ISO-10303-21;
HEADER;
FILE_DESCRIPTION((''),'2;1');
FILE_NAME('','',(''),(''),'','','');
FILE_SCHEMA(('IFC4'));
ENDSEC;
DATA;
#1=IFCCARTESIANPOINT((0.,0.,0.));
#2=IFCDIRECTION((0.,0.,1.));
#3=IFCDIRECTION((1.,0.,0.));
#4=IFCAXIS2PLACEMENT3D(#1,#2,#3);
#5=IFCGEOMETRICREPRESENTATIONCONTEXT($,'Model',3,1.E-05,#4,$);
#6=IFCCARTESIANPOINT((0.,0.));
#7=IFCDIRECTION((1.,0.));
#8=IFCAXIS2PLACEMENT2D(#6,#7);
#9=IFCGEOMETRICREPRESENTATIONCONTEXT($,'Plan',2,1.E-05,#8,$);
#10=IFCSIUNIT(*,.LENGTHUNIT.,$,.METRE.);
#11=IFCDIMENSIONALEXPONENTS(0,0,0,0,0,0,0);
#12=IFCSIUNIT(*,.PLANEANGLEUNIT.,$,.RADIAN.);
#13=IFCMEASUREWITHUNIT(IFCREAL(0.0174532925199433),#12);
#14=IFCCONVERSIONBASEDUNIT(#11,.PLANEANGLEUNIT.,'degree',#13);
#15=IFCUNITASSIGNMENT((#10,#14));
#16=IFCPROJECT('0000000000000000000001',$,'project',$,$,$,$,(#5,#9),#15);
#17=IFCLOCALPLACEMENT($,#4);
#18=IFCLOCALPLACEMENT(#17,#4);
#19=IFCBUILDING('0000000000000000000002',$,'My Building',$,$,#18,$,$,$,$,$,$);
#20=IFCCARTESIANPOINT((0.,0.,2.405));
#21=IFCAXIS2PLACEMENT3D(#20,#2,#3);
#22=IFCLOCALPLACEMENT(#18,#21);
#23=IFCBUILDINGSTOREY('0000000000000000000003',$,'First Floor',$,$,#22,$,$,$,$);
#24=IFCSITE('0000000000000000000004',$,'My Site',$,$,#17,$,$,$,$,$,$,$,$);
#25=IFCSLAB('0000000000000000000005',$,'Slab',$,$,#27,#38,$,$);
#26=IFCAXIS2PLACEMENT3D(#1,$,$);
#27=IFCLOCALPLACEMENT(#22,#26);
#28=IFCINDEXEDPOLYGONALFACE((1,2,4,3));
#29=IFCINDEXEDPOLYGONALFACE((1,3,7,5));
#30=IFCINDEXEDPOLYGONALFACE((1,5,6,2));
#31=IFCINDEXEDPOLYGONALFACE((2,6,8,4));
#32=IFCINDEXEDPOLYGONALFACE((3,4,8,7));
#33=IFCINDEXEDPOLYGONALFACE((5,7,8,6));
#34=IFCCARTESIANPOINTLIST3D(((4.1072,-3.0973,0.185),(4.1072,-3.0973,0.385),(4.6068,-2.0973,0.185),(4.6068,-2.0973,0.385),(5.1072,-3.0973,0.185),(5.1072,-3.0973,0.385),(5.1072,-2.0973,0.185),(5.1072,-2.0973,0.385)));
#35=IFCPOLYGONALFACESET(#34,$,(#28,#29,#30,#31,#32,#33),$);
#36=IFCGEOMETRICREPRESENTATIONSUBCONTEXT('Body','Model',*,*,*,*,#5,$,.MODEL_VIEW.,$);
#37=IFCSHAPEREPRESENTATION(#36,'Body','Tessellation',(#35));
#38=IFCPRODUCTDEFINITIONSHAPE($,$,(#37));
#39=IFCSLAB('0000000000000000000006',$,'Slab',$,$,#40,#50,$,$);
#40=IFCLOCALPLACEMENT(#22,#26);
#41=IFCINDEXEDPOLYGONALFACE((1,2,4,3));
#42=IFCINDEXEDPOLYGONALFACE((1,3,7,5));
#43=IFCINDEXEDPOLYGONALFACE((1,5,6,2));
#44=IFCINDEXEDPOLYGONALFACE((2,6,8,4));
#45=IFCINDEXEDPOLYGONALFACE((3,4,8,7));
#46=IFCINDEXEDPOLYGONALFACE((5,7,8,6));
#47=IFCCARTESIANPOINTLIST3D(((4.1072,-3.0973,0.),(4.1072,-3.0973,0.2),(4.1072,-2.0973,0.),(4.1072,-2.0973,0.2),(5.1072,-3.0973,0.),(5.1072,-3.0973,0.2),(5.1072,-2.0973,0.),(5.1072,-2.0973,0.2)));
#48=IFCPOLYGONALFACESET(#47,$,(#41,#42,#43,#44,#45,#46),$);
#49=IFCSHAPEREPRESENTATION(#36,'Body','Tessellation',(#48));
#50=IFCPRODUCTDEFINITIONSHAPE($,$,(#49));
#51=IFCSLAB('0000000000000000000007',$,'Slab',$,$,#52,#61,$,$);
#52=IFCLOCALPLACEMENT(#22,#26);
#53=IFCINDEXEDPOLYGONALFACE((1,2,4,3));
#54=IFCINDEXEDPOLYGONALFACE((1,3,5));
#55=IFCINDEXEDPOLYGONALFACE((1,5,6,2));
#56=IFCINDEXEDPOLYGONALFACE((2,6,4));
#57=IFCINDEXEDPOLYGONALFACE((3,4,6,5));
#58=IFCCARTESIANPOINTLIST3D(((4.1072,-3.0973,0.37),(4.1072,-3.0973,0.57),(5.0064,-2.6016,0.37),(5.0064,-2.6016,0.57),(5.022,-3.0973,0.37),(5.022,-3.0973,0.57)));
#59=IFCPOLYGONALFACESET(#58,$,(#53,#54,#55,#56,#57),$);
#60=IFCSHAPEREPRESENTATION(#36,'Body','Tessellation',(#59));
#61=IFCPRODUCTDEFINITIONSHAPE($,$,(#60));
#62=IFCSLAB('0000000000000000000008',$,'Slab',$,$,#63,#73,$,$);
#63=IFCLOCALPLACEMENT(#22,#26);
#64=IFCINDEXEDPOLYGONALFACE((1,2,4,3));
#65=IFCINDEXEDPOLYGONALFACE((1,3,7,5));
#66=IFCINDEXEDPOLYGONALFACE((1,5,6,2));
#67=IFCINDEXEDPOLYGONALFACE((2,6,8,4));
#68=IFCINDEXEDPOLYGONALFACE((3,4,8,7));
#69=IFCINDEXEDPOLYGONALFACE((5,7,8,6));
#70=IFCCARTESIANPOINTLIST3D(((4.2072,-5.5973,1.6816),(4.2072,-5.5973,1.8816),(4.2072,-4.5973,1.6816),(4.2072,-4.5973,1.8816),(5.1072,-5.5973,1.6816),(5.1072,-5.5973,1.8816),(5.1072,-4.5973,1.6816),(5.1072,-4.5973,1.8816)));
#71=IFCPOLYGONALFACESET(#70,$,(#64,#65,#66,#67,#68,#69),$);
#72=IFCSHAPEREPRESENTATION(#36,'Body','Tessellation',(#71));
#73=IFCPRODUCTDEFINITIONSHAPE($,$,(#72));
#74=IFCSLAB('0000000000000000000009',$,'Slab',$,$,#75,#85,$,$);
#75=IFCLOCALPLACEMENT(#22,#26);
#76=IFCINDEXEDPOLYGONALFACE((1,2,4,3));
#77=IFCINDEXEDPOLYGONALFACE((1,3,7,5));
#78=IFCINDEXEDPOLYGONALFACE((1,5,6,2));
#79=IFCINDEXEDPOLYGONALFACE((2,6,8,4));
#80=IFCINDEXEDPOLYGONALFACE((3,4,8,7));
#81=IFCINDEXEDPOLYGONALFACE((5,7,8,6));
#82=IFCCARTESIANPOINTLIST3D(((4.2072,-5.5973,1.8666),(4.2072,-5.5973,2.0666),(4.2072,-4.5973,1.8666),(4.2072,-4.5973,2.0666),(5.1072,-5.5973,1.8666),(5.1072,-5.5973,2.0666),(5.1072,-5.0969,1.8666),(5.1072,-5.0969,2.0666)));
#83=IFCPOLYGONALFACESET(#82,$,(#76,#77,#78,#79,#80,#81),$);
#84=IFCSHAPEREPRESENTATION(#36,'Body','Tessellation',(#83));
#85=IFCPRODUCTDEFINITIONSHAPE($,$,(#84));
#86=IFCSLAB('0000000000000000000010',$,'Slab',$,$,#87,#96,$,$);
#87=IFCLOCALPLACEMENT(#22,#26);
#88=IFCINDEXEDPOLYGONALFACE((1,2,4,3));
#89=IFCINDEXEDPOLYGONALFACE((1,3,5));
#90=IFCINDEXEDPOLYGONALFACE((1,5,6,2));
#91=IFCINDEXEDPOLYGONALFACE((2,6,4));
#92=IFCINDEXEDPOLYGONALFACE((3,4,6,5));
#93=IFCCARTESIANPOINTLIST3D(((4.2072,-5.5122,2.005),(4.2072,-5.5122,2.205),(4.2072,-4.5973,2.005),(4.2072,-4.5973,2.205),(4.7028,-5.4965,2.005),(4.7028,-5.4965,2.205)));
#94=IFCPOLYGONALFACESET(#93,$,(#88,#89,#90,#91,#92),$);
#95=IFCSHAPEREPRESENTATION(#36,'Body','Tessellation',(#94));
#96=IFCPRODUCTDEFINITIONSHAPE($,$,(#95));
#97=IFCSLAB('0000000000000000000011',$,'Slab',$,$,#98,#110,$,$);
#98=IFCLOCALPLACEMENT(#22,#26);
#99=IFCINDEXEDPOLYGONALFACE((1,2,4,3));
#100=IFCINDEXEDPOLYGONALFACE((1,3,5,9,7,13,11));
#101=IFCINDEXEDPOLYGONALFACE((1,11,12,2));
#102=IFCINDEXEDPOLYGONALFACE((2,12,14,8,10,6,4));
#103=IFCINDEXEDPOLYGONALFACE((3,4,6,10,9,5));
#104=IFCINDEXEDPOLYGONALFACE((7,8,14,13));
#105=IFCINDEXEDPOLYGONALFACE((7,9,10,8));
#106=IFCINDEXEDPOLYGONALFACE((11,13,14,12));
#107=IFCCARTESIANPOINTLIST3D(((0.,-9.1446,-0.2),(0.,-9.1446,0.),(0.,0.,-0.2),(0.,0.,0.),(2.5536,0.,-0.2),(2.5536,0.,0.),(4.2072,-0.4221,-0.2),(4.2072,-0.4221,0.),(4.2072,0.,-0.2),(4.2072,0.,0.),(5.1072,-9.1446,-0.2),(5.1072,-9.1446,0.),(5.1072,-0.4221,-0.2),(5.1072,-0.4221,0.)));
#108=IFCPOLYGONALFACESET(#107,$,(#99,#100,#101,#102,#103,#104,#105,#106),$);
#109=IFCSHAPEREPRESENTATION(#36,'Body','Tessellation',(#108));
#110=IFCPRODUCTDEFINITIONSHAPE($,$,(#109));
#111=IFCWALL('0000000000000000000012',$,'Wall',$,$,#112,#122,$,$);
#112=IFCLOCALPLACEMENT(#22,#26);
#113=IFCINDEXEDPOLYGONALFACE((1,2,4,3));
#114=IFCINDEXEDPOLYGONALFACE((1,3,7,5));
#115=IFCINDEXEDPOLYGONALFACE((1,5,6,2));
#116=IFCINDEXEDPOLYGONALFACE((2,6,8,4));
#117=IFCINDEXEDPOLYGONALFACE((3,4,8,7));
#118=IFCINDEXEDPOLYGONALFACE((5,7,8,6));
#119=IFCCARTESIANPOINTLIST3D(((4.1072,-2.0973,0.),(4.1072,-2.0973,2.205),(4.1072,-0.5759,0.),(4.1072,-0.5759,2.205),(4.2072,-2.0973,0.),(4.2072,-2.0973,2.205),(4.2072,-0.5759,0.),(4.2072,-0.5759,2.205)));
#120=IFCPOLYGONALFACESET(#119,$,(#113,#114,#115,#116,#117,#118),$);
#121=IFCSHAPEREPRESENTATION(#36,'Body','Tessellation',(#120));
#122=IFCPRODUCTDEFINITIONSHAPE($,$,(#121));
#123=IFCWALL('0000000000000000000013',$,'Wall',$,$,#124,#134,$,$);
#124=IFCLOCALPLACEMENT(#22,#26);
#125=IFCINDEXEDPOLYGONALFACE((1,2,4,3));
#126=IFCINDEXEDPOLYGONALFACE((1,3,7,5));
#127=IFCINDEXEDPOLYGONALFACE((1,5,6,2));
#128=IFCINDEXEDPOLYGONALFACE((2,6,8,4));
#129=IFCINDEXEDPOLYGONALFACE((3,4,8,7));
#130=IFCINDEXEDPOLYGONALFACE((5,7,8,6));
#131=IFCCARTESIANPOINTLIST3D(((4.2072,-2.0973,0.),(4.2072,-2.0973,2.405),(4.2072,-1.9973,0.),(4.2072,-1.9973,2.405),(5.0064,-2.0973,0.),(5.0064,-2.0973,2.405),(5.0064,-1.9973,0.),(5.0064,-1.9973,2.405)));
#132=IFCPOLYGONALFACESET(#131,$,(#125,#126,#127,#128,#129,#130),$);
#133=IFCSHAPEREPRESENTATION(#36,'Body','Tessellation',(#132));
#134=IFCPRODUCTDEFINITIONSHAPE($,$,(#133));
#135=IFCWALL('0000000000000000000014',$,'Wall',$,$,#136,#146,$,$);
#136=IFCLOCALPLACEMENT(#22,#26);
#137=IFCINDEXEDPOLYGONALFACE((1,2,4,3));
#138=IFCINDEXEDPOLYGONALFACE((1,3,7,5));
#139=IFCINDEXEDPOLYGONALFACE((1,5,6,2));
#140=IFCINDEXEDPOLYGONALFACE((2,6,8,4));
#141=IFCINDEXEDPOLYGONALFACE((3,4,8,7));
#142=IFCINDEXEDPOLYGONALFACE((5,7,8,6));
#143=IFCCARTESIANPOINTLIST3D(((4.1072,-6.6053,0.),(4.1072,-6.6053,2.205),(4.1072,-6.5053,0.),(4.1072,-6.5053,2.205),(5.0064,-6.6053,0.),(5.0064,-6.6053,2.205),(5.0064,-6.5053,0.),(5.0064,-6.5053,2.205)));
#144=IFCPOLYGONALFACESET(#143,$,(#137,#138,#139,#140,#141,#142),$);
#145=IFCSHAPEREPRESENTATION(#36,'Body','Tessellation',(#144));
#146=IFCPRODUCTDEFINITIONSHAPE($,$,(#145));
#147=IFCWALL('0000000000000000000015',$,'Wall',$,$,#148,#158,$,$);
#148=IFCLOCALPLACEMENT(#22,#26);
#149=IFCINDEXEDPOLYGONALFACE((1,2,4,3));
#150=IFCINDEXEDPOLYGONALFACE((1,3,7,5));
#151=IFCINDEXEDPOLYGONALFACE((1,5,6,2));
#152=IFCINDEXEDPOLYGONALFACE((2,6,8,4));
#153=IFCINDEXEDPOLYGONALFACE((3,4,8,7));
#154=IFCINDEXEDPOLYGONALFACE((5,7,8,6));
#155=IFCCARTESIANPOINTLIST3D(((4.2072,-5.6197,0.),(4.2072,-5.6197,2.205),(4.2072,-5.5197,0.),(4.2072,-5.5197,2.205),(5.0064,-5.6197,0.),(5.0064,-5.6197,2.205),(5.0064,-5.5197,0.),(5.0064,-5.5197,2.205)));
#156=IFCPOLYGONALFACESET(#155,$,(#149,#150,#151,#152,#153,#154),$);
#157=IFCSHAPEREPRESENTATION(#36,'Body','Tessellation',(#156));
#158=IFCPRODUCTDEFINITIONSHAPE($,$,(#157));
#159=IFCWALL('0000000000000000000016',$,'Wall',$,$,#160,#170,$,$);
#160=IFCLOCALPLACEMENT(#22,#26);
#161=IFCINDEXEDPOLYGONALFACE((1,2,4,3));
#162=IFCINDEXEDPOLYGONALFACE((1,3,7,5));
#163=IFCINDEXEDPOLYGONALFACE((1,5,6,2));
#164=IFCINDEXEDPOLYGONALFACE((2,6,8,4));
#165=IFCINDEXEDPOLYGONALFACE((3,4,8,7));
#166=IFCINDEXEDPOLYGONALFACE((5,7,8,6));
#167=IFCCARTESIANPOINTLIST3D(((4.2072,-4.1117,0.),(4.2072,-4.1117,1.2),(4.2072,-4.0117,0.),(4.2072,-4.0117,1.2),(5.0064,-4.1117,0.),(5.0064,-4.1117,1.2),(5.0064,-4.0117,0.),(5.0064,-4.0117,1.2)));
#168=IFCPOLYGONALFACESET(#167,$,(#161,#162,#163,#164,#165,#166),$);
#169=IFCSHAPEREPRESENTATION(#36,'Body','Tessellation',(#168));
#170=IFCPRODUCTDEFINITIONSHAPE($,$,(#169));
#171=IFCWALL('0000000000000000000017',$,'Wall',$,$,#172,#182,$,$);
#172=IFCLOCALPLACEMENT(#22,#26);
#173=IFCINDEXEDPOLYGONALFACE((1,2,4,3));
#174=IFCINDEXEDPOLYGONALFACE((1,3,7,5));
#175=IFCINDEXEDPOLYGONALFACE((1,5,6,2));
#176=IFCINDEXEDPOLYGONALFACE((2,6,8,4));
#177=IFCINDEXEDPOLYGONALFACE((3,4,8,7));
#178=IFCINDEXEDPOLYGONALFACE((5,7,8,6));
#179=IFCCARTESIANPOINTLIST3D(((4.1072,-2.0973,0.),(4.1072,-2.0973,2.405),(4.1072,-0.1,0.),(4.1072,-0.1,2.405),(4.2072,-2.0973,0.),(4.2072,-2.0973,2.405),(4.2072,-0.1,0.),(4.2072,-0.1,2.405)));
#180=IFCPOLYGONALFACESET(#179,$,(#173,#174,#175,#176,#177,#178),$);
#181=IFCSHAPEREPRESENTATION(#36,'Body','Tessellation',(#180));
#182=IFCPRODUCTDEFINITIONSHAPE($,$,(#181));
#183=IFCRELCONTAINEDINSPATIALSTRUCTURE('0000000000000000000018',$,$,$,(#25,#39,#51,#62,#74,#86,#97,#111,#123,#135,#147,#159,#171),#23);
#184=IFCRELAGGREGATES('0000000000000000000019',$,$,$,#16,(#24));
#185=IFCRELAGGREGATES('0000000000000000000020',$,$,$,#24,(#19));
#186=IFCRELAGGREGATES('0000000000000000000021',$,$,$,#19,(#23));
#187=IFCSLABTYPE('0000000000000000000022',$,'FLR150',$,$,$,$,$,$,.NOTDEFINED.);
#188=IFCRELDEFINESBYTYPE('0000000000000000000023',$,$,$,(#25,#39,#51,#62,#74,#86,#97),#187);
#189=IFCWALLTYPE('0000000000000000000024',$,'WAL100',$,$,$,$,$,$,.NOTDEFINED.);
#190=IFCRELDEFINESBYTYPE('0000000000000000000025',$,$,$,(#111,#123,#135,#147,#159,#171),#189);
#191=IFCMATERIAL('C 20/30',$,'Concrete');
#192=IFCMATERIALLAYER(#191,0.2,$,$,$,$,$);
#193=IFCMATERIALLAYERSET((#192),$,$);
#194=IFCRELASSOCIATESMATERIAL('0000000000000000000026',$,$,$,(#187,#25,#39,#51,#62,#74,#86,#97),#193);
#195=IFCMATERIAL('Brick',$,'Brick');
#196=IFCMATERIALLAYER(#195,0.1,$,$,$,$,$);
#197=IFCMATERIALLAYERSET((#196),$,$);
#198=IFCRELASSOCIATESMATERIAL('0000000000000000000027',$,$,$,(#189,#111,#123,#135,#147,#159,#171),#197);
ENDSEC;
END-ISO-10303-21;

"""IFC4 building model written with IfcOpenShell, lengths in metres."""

from ifc_helpers import new_model, entity, si_unit, converted_unit, frame, origin_with_axes, origin_2d_with_axis, place, context, subcontext, project, spatial, line, indexed_curve, outline, extrude, material, layer, layer_set, layer_usage, type_object, element, save


model = new_model("IFC4")

# Units and contexts
model_context = context("Model", 3, precision=1e-05, world=origin_with_axes())
plan_context = context("Plan", 2, precision=1e-05, world=origin_2d_with_axis())
body_context = subcontext(model_context, "Body", "Model", "MODEL_VIEW")
ifc_project = project(units=[si_unit("LENGTHUNIT", "METRE"), converted_unit("PLANEANGLEUNIT", "degree", entity("IfcReal", 0.0174532925199433), si_unit("PLANEANGLEUNIT", "RADIAN"), dimensions=[0, 0, 0, 0, 0, 0, 0])], contexts=[model_context, plan_context])

# Site, building, storey
site_placement = place(None, origin_with_axes())
site = spatial("IfcSite", under=ifc_project, at=site_placement, Name="My Site")
building_placement = place(site_placement, origin_with_axes())
building = spatial("IfcBuilding", under=site, at=building_placement, Name="My Building")
storey_placement = place(building_placement, frame((0.0, 0.0, 2.405), z_axis=(0.0, 0.0, 1.0), x_axis=(1.0, 0.0, 0.0)))
storey = spatial("IfcBuildingStorey", under=building, at=storey_placement, Name="First Floor")

# Slabs
ifc_material_1 = material(Name="C 20/30", Category="Concrete")
ifc_layer_1 = layer(ifc_material_1, 0.2)
ifc_layer_set_1 = layer_set([ifc_layer_1])
ifc_layer_usage_1 = layer_usage(ifc_layer_set_1, "AXIS3", "POSITIVE", 0.0)
slab_type = type_object("IfcSlabType", Name="FLR150", PredefinedType="NOTDEFINED", material=ifc_layer_set_1)
slab_1_placement = place(storey_placement, frame((4.1072, -3.0973, 0.185), z_axis=(0.0, 0.0, 1.0), x_axis=(1.0, 0.0, 0.0)))
element("IfcSlab", 1, at=slab_1_placement, inside=storey, type_object=slab_type, material=ifc_layer_usage_1, Name="Slab", context=body_context, shape_type="SweptSolid", body=[
    extrude(outline(indexed_curve([(0.0, 0.0), (1.0, 0.0), (1.0, 1.0), (0.4996, 1.0)], segments=[line(3, 2), line(2, 1), line(1, 4), line(4, 3)], self_intersect=False)), None, (0.0, 0.0, 1.0), 0.2),
])
ifc_layer_usage_2 = layer_usage(ifc_layer_set_1, "AXIS3", "POSITIVE", 0.0)
slab_2_placement = place(storey_placement, frame((4.1072, -3.0973, 0.0), z_axis=(0.0, 0.0, 1.0), x_axis=(1.0, 0.0, 0.0)))
element("IfcSlab", 2, at=slab_2_placement, inside=storey, type_object=slab_type, material=ifc_layer_usage_2, Name="Slab", context=body_context, shape_type="SweptSolid", body=[
    extrude(outline(indexed_curve([(0.0, 0.0), (1.0, 0.0), (1.0, 1.0), (0.0, 1.0), (0.0, 0.0)])), None, (0.0, 0.0, 1.0), 0.2),
])
ifc_layer_usage_3 = layer_usage(ifc_layer_set_1, "AXIS3", "POSITIVE", 0.0)
slab_3_placement = place(storey_placement, frame((4.1072, -3.0973, 0.37), z_axis=(0.0, 0.0, 1.0), x_axis=(1.0, 0.0, 0.0)))
element("IfcSlab", 3, at=slab_3_placement, inside=storey, type_object=slab_type, material=ifc_layer_usage_3, Name="Slab", context=body_context, shape_type="SweptSolid", body=[
    extrude(outline(indexed_curve([(0.0, 0.0), (0.9149, 0.0), (0.8992, 0.4957)], segments=[line(1, 3), line(3, 2), line(2, 1)], self_intersect=False)), None, (0.0, 0.0, 1.0), 0.2),
])
ifc_layer_usage_4 = layer_usage(ifc_layer_set_1, "AXIS3", "POSITIVE", 0.0)
slab_4_placement = place(storey_placement, frame((4.2072, -4.5973, 1.6816), z_axis=(0.0, 0.0, 1.0), x_axis=(0.0, -1.0, 0.0)))
element("IfcSlab", 4, at=slab_4_placement, inside=storey, type_object=slab_type, material=ifc_layer_usage_4, Name="Slab", context=body_context, shape_type="SweptSolid", body=[
    extrude(outline(indexed_curve([(0.0, 0.0), (1.0, 0.0), (1.0, 0.9), (0.0, 0.9)], segments=[line(4, 1), line(1, 2), line(2, 3), line(3, 4)], self_intersect=False)), None, (0.0, 0.0, 1.0), 0.2),
])
ifc_layer_usage_5 = layer_usage(ifc_layer_set_1, "AXIS3", "POSITIVE", 0.0)
slab_5_placement = place(storey_placement, frame((4.2072, -4.5973, 1.8666), z_axis=(0.0, 0.0, 1.0), x_axis=(0.0, -1.0, 0.0)))
element("IfcSlab", 5, at=slab_5_placement, inside=storey, type_object=slab_type, material=ifc_layer_usage_5, Name="Slab", context=body_context, shape_type="SweptSolid", body=[
    extrude(outline(indexed_curve([(1.0, 0.0), (1.0, 0.9), (0.4996, 0.9), (0.0, 0.0)], segments=[line(4, 1), line(1, 2), line(2, 3), line(3, 4)], self_intersect=False)), None, (0.0, 0.0, 1.0), 0.2),
])
ifc_layer_usage_6 = layer_usage(ifc_layer_set_1, "AXIS3", "POSITIVE", 0.0)
slab_6_placement = place(storey_placement, frame((4.2072, -4.5973, 2.005), z_axis=(0.0, 0.0, 1.0), x_axis=(0.0, -1.0, 0.0)))
element("IfcSlab", 6, at=slab_6_placement, inside=storey, type_object=slab_type, material=ifc_layer_usage_6, Name="Slab", context=body_context, shape_type="SweptSolid", body=[
    extrude(outline(indexed_curve([(0.0, 0.0), (0.9149, 0.0), (0.8992, 0.4957)], segments=[line(1, 3), line(3, 2), line(2, 1)], self_intersect=False)), None, (0.0, 0.0, 1.0), 0.2),
])
ifc_layer_usage_7 = layer_usage(ifc_layer_set_1, "AXIS3", "POSITIVE", 0.0)
slab_7_placement = place(storey_placement, frame((0.0, -9.1446, -0.2), z_axis=(0.0, 0.0, 1.0), x_axis=(1.0, 0.0, 0.0)))
element("IfcSlab", 7, at=slab_7_placement, inside=storey, type_object=slab_type, material=ifc_layer_usage_7, Name="Slab", context=body_context, shape_type="SweptSolid", body=[
    extrude(outline(indexed_curve([(0.0, 9.1446), (2.5536, 9.1446), (4.2072, 9.1446), (5.1072, 8.7225), (5.1072, 0.0), (0.0, 0.0), (4.2072, 8.7225)], segments=[line(3, 2), line(2, 1), line(1, 6), line(6, 5), line(5, 4), line(4, 7), line(7, 3)], self_intersect=False)), None, (0.0, 0.0, 1.0), 0.2),
])

# Walls
ifc_material_2 = material(Name="Brick", Category="Brick")
ifc_layer_2 = layer(ifc_material_2, 0.1)
ifc_layer_set_2 = layer_set([ifc_layer_2])
ifc_layer_usage_8 = layer_usage(ifc_layer_set_2, "AXIS2", "POSITIVE", 0.0)
wall_type = type_object("IfcWallType", Name="WAL100", PredefinedType="NOTDEFINED", material=ifc_layer_set_2)
wall_1_placement = place(storey_placement, frame((4.1072, -0.5759, 0.0), z_axis=(0.0, 0.0, 1.0), x_axis=(-0.000001, -1.0, 0.0)))
element("IfcWall", 8, at=wall_1_placement, inside=storey, type_object=wall_type, material=ifc_layer_usage_8, Name="Wall", context=body_context, shape_type="SweptSolid", body=[
    extrude(outline(indexed_curve([(0.0, 0.0), (0.0, 0.1), (1.5214, 0.1), (1.5214, 0.0), (0.0, 0.0)], self_intersect=False)), origin_with_axes(), (0.0, 0.0, 1.0), 2.205),
])
ifc_layer_usage_9 = layer_usage(ifc_layer_set_2, "AXIS2", "POSITIVE", 0.0)
wall_2_placement = place(storey_placement, frame((5.0064, -1.9973, 0.0), z_axis=(0.0, 0.0, 1.0), x_axis=(-1.0, 0.000001, 0.0)))
element("IfcWall", 9, at=wall_2_placement, inside=storey, type_object=wall_type, material=ifc_layer_usage_9, Name="Wall", context=body_context, shape_type="SweptSolid", body=[
    extrude(outline(indexed_curve([(0.0, 0.0), (0.0, 0.1), (0.7992, 0.1), (0.7992, 0.0), (0.0, 0.0)], self_intersect=False)), origin_with_axes(), (0.0, 0.0, 1.0), 2.405),
])
ifc_layer_usage_10 = layer_usage(ifc_layer_set_2, "AXIS2", "POSITIVE", 0.0)
wall_3_placement = place(storey_placement, frame((5.0064, -6.5053, 0.0), z_axis=(0.0, 0.0, 1.0), x_axis=(-1.0, 0.000001, 0.0)))
element("IfcWall", 10, at=wall_3_placement, inside=storey, type_object=wall_type, material=ifc_layer_usage_10, Name="Wall", context=body_context, shape_type="SweptSolid", body=[
    extrude(outline(indexed_curve([(0.0, 0.0), (0.0, 0.1), (0.8992, 0.1), (0.8992, 0.0), (0.0, 0.0)], self_intersect=False)), origin_with_axes(), (0.0, 0.0, 1.0), 2.205),
])
ifc_layer_usage_11 = layer_usage(ifc_layer_set_2, "AXIS2", "POSITIVE", 0.0)
wall_4_placement = place(storey_placement, frame((5.0064, -5.5197, 0.0), z_axis=(0.0, 0.0, 1.0), x_axis=(-1.0, 0.000001, 0.0)))
element("IfcWall", 11, at=wall_4_placement, inside=storey, type_object=wall_type, material=ifc_layer_usage_11, Name="Wall", context=body_context, shape_type="SweptSolid", body=[
    extrude(outline(indexed_curve([(0.0, 0.0), (0.0, 0.1), (0.7992, 0.1), (0.7992, 0.0), (0.0, 0.0)], self_intersect=False)), origin_with_axes(), (0.0, 0.0, 1.0), 2.205),
])
ifc_layer_usage_12 = layer_usage(ifc_layer_set_2, "AXIS2", "POSITIVE", 0.0)
wall_5_placement = place(storey_placement, frame((5.0064, -4.0117, 0.0), z_axis=(0.0, 0.0, 1.0), x_axis=(-1.0, 0.000001, 0.0)))
element("IfcWall", 12, at=wall_5_placement, inside=storey, type_object=wall_type, material=ifc_layer_usage_12, Name="Wall", context=body_context, shape_type="SweptSolid", body=[
    extrude(outline(indexed_curve([(0.0, 0.0), (0.0, 0.1), (0.7992, 0.1), (0.7992, 0.0), (0.0, 0.0)], self_intersect=False)), origin_with_axes(), (0.0, 0.0, 1.0), 1.2),
])
ifc_layer_usage_13 = layer_usage(ifc_layer_set_2, "AXIS2", "POSITIVE", 0.0)
wall_6_placement = place(storey_placement, frame((4.1072, -0.1, 0.0), z_axis=(0.0, 0.0, 1.0), x_axis=(-0.000001, -1.0, 0.0)))
element("IfcWall", 13, at=wall_6_placement, inside=storey, type_object=wall_type, material=ifc_layer_usage_13, Name="Wall", context=body_context, shape_type="SweptSolid", body=[
    extrude(outline(indexed_curve([(0.0, 0.0), (0.0, 0.1), (1.9973, 0.1), (1.9973, 0.0), (0.0, 0.0)], self_intersect=False)), origin_with_axes(), (0.0, 0.0, 1.0), 2.405),
])

save(model, "model.ifc")
